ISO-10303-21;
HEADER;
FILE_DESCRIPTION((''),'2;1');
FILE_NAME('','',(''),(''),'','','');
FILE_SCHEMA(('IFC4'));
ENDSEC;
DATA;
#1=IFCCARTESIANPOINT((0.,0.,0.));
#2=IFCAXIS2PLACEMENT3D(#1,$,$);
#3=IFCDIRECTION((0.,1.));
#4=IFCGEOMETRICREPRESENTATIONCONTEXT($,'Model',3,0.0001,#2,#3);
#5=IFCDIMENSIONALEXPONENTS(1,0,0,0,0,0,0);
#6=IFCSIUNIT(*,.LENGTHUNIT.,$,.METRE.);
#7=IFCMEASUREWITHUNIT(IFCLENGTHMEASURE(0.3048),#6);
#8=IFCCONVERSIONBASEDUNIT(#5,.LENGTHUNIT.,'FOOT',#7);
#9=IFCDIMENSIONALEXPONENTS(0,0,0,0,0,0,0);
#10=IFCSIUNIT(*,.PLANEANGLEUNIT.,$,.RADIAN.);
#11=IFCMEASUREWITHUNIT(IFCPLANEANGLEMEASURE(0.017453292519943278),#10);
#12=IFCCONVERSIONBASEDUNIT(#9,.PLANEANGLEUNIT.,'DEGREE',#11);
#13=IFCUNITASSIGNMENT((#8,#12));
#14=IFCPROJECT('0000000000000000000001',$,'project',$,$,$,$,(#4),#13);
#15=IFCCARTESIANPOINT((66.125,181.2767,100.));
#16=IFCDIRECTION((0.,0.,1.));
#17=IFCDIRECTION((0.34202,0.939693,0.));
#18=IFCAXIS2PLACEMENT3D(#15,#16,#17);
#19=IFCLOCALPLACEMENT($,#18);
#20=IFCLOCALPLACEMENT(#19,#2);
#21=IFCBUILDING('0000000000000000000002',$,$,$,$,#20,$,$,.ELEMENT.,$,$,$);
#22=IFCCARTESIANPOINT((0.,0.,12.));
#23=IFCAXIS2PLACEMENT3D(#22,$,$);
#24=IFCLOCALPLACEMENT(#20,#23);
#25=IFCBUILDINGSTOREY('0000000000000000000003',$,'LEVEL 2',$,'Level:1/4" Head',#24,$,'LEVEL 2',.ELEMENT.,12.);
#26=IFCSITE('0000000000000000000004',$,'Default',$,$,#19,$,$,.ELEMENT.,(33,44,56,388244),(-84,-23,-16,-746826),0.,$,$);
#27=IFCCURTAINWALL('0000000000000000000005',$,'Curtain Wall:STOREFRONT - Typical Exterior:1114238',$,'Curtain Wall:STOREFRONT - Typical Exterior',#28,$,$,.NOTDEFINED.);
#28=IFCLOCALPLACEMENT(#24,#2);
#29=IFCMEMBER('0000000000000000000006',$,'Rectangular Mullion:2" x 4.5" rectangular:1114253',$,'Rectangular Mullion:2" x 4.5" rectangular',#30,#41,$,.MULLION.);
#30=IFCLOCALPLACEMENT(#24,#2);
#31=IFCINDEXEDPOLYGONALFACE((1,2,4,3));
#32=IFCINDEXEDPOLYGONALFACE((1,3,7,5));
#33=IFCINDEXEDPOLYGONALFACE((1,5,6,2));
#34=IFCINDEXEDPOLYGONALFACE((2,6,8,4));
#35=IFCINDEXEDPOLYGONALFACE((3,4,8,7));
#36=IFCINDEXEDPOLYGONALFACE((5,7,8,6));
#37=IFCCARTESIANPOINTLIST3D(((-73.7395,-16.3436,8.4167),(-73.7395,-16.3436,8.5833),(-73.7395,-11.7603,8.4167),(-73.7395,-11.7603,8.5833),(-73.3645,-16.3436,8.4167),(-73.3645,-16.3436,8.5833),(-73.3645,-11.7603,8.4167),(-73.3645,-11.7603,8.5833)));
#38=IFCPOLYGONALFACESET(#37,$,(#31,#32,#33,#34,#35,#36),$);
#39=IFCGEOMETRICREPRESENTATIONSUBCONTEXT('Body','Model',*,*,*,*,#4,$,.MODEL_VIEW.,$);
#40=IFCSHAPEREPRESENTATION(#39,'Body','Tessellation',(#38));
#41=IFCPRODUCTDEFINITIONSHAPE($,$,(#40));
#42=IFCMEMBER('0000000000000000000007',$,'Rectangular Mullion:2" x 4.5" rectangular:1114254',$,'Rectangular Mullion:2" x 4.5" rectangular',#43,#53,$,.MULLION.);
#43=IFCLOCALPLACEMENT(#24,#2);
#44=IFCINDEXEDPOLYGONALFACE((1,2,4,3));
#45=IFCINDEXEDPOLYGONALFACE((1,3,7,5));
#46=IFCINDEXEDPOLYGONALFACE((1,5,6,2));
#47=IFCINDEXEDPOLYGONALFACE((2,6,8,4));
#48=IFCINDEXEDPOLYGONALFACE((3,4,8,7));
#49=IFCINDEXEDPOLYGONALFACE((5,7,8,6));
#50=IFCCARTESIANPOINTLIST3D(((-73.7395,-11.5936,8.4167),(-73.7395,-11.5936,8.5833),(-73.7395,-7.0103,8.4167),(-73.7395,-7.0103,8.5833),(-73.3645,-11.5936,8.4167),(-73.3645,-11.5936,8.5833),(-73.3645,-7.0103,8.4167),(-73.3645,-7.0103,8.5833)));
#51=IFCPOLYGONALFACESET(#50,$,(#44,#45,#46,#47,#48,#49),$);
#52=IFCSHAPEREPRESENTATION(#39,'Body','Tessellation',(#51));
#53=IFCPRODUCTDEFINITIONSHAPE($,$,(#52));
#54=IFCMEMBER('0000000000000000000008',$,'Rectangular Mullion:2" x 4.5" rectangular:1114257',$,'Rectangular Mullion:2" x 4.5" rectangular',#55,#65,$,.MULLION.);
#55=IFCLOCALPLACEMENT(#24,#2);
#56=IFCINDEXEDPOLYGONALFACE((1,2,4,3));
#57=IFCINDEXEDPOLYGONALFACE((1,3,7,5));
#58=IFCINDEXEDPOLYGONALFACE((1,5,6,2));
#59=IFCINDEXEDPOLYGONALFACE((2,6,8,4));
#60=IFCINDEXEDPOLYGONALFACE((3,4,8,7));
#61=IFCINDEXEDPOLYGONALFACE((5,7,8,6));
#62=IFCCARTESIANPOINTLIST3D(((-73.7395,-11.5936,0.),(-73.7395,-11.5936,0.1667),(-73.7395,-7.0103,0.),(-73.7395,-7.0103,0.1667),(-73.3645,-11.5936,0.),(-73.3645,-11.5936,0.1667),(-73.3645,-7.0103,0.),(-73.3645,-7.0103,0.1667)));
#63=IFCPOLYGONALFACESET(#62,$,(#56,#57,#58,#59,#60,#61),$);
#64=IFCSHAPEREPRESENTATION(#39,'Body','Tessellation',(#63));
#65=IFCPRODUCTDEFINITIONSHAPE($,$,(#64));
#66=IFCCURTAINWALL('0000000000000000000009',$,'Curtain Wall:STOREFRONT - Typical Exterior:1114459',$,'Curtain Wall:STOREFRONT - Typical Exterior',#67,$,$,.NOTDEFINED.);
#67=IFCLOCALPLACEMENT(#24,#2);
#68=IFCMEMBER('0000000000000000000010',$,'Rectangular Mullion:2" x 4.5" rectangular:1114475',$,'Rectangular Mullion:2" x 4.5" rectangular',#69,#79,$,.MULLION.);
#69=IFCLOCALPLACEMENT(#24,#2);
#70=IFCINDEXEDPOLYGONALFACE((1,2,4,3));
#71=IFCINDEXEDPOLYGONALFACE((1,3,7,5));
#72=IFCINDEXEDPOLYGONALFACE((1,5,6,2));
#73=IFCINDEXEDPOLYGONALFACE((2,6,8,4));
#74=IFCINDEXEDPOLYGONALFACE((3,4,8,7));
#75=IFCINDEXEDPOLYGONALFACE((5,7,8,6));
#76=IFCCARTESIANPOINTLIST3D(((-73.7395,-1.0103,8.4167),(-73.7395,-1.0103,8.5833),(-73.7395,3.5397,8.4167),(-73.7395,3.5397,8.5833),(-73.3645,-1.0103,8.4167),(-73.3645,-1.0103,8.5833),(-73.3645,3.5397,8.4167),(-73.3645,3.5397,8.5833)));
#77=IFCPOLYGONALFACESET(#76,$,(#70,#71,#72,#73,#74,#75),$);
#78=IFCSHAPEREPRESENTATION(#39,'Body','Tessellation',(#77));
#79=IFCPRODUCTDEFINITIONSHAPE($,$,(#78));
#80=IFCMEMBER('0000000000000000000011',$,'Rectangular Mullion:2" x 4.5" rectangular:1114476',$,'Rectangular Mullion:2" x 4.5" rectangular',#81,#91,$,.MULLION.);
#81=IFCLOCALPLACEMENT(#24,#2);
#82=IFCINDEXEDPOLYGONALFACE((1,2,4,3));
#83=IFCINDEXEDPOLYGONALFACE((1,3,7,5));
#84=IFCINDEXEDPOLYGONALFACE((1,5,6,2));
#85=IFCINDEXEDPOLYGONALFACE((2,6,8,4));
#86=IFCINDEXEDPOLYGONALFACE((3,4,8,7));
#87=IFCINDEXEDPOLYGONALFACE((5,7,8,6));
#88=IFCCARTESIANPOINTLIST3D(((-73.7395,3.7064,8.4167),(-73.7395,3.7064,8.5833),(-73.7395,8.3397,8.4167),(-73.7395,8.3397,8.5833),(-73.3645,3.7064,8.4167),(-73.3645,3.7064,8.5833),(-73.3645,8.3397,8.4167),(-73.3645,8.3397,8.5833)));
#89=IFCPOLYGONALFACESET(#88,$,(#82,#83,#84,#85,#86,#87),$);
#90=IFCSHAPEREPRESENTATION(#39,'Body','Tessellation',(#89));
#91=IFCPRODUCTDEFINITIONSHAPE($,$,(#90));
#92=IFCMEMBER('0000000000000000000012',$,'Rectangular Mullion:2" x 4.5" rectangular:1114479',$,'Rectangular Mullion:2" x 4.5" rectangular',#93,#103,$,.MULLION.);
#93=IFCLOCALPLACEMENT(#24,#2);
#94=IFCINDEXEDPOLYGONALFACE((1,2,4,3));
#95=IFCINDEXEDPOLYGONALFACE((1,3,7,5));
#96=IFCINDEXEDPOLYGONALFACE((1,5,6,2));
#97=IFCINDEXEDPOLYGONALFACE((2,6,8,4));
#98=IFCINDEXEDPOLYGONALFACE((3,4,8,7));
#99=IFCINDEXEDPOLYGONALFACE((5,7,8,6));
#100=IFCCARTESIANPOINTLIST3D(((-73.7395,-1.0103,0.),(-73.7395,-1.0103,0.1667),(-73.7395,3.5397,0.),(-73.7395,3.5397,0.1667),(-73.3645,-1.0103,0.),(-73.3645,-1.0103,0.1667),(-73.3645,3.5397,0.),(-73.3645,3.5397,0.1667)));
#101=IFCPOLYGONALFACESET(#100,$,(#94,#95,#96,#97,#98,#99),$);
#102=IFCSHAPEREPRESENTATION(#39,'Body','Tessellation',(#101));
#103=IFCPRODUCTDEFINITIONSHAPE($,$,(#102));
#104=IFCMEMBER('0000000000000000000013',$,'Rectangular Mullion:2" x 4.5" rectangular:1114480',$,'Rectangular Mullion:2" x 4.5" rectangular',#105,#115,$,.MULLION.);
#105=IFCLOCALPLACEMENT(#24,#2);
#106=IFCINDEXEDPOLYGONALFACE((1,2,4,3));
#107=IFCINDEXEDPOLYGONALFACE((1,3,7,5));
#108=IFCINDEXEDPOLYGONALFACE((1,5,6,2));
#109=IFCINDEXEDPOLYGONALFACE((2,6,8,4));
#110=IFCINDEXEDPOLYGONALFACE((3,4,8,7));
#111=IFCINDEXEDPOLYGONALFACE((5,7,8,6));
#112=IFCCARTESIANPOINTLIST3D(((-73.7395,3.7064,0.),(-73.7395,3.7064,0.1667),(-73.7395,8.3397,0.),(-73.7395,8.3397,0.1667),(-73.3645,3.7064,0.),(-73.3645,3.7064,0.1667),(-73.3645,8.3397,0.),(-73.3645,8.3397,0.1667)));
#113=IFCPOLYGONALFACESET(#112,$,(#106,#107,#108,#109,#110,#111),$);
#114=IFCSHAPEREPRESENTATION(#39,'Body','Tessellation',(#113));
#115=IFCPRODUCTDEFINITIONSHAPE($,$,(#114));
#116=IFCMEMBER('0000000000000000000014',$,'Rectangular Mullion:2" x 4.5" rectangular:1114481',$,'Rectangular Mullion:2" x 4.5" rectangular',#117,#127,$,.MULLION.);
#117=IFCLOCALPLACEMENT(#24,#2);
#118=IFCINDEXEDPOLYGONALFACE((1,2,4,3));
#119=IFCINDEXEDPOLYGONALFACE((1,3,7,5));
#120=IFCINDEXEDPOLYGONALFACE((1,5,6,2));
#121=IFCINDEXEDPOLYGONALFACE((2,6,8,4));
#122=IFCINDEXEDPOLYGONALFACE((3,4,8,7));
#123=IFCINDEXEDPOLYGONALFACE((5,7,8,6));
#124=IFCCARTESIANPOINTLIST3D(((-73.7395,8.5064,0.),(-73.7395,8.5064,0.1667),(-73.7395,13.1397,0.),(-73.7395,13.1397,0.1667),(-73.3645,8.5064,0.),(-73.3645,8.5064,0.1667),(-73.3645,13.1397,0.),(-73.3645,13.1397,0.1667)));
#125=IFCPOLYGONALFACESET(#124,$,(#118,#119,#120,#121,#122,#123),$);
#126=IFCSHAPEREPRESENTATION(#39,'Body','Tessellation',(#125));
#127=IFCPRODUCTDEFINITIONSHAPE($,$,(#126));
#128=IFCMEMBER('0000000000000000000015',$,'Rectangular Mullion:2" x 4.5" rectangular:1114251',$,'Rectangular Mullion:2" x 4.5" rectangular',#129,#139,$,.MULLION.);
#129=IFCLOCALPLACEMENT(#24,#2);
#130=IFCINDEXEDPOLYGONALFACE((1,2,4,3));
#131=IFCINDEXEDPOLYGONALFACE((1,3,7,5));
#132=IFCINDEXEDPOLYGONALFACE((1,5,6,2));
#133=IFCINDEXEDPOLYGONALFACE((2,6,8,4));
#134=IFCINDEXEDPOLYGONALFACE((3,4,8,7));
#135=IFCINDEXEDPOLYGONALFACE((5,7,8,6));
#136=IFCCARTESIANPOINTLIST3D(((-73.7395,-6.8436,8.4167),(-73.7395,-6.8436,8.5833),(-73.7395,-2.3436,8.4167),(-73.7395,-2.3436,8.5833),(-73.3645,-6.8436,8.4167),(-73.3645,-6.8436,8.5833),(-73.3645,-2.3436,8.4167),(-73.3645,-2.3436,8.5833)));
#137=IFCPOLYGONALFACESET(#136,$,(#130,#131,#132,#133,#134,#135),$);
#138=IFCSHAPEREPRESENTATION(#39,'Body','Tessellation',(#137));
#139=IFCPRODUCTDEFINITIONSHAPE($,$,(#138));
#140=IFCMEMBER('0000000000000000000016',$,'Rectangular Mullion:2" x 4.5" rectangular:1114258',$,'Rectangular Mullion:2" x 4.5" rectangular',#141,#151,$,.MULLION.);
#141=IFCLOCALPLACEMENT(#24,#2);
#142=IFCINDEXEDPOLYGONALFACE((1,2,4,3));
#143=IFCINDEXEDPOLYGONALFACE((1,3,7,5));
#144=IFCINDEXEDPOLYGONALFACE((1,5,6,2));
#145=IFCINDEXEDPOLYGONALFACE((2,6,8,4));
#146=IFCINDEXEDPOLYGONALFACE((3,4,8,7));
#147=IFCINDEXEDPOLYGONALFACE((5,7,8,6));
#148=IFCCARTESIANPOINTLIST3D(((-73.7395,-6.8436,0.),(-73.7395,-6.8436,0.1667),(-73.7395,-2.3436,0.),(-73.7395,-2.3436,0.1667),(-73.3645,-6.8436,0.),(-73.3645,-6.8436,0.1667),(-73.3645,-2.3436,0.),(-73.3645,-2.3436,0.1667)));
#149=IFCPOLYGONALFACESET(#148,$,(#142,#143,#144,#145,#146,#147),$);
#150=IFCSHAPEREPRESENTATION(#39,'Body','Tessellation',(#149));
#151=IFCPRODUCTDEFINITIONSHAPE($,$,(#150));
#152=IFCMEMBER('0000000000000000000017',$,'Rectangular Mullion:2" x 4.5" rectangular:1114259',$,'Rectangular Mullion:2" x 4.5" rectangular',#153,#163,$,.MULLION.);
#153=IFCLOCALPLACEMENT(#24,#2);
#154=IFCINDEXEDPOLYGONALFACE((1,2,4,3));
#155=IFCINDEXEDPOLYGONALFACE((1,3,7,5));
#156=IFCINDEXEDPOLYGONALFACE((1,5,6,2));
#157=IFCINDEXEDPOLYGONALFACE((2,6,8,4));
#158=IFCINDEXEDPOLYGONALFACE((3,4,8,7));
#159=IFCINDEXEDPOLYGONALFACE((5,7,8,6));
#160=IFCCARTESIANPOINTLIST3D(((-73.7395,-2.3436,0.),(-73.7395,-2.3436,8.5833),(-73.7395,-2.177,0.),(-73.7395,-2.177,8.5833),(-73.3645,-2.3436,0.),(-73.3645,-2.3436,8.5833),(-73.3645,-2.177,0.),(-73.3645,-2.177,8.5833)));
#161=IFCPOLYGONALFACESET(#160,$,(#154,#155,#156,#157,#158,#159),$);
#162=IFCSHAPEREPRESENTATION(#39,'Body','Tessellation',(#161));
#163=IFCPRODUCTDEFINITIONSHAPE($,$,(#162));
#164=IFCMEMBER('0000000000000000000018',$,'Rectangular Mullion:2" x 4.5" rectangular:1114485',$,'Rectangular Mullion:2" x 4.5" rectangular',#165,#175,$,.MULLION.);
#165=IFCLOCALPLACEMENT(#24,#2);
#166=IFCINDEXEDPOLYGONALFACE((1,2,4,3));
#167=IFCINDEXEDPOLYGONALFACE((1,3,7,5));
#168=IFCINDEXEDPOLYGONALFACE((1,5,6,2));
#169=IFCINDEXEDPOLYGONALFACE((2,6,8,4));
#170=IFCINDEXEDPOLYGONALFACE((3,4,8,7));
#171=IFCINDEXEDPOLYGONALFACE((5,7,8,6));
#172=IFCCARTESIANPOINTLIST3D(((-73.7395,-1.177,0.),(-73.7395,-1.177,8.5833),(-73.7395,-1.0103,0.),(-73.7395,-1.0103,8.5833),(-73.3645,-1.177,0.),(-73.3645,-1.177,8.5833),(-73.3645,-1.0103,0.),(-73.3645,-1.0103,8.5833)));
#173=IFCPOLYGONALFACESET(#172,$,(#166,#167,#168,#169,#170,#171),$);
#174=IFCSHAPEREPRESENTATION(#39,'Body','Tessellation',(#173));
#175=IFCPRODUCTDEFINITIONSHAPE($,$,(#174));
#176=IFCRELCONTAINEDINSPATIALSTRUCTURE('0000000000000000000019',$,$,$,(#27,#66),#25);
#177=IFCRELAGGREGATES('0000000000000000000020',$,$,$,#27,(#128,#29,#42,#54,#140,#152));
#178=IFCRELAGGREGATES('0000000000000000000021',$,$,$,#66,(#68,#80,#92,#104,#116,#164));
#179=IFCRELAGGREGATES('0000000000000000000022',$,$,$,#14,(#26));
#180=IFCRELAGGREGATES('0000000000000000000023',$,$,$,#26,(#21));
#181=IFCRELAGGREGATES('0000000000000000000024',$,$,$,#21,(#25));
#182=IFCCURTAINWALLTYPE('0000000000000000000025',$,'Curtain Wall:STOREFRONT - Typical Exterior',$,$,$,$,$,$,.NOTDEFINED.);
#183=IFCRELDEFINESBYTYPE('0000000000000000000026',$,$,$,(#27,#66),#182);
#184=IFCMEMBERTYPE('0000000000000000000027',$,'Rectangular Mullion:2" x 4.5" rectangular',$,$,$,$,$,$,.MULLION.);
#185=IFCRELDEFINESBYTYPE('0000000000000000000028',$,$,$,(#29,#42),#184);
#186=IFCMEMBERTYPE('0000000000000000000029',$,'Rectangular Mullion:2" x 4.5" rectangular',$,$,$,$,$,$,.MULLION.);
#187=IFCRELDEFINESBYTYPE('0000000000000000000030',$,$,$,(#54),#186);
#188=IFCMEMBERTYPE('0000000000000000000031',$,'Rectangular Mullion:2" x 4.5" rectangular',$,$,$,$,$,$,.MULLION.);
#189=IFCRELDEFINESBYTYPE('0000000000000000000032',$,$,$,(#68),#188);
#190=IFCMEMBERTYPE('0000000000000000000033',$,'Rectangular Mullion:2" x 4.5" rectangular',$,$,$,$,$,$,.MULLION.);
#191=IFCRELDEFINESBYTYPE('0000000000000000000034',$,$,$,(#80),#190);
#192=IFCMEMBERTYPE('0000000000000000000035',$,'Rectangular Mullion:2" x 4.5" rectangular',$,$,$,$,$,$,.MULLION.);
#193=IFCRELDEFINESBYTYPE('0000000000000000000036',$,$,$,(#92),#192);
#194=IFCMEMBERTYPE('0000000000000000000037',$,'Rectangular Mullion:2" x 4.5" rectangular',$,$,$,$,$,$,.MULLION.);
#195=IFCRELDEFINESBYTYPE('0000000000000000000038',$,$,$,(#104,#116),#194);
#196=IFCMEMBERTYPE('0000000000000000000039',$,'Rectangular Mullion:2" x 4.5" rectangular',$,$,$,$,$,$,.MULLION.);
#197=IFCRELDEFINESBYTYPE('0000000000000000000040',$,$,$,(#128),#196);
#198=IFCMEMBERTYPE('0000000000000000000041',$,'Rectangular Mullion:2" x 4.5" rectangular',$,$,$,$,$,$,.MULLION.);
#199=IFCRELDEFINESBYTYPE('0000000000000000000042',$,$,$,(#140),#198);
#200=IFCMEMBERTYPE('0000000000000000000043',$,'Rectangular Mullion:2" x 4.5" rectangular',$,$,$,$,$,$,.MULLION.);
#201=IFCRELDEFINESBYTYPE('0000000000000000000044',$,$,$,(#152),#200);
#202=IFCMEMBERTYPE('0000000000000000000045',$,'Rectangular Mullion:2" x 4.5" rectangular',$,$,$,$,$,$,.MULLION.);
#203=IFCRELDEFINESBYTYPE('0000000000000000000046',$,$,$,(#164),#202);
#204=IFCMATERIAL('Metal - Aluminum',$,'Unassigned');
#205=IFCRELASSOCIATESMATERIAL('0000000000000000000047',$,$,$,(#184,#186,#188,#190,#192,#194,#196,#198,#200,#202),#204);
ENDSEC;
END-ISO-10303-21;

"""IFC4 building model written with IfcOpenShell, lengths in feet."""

from ifc_helpers import new_model, entity, si_unit, converted_unit, direction, frame, origin, origin_2d_with_axis, place, context, subcontext, project, spatial, rectangle, extrude, source, transform, mapped, material, material_profile, profile_set, type_object, type_shapes, element, aggregate, save


model = new_model("IFC4")

# Units and contexts
model_context = context("Model", 3, precision=0.0001, world=origin(), true_north=direction((0.0, 1.0)))
body_context = subcontext(model_context, "Body", "Model", "MODEL_VIEW")
ifc_project = project(units=[converted_unit("LENGTHUNIT", "FOOT", entity("IfcLengthMeasure", 0.3048), si_unit("LENGTHUNIT", "METRE"), dimensions=[1, 0, 0, 0, 0, 0, 0]), converted_unit("PLANEANGLEUNIT", "DEGREE", entity("IfcPlaneAngleMeasure", 0.017453292519943278), si_unit("PLANEANGLEUNIT", "RADIAN"), dimensions=[0, 0, 0, 0, 0, 0, 0])], contexts=[model_context])

# Site, building, storey
site_placement = place(None, frame((66.125, 181.2767, 100.0), z_axis=(0.0, 0.0, 1.0), x_axis=(0.34202, 0.939693, 0.0)))
site = spatial("IfcSite", under=ifc_project, at=site_placement, Name="Default", CompositionType="ELEMENT", RefLatitude=(33, 44, 56, 388244), RefLongitude=(-84, -23, -16, -746826), RefElevation=0.0)
building_placement = place(site_placement, origin())
building = spatial("IfcBuilding", under=site, at=building_placement, CompositionType="ELEMENT")
storey_placement = place(building_placement, frame((0.0, 0.0, 12.0)))
storey = spatial("IfcBuildingStorey", under=building, at=storey_placement, Name="LEVEL 2", ObjectType="Level:1/4\" Head", LongName="LEVEL 2", CompositionType="ELEMENT", Elevation=12.0)

# Curtain walls, members
curtain_wall_type = type_object("IfcCurtainWallType", Name="Curtain Wall:STOREFRONT - Typical Exterior", PredefinedType="NOTDEFINED")
curtain_wall_1_placement = place(storey_placement, frame((0.0, 0.0, -12.0)))
curtain_wall_1 = element("IfcCurtainWall", 1, at=curtain_wall_1_placement, inside=storey, type_object=curtain_wall_type, Name="Curtain Wall:STOREFRONT - Typical Exterior:1114238", ObjectType="Curtain Wall:STOREFRONT - Typical Exterior", PredefinedType="NOTDEFINED")
ifc_material_1 = material(Name="Metal - Aluminum", Category="Unassigned")
ifc_material_profile = material_profile(ifc_material_1, rectangle(XDim=0.1667, YDim=0.375, at=origin_2d_with_axis()), Name="2\" x 4.5\" rectangular")
ifc_profile_set = profile_set([ifc_material_profile], Name="2\" x 4.5\" rectangular")
member_type_1 = type_object("IfcMemberType", Name="Rectangular Mullion:2\" x 4.5\" rectangular", PredefinedType="MULLION", material=ifc_profile_set)
shared_shape_1 = source(origin(), body_context, "Body", "SweptSolid", [
    extrude(rectangle(XDim=0.1667, YDim=0.375, at=origin_2d_with_axis()), frame((-0.0833, 0.0, -4.5833), z_axis=(0.0, 0.0, 1.0), x_axis=(-1.0, 0.0, 0.0)), (0.0, 0.0, 1.0), 4.5833),
])
type_shapes(member_type_1, [shared_shape_1])
member_1_placement = place(curtain_wall_1_placement, frame((-73.552, -11.7603, 20.5833), z_axis=(0.0, 1.0, 0.0), x_axis=(0.0, 0.0, 1.0)))
member_1 = element("IfcMember", 2, at=member_1_placement, type_object=member_type_1, Name="Rectangular Mullion:2\" x 4.5\" rectangular:1114253", ObjectType="Rectangular Mullion:2\" x 4.5\" rectangular", PredefinedType="MULLION", context=body_context, shape_type="MappedRepresentation", body=[
    mapped(shared_shape_1, transform((0.0, 0.0, 0.0), scale=1.0)),
])
member_2_placement = place(curtain_wall_1_placement, frame((-73.552, -7.0103, 20.5833), z_axis=(0.0, 1.0, 0.0), x_axis=(0.0, 0.0, 1.0)))
member_2 = element("IfcMember", 3, at=member_2_placement, type_object=member_type_1, Name="Rectangular Mullion:2\" x 4.5\" rectangular:1114254", ObjectType="Rectangular Mullion:2\" x 4.5\" rectangular", PredefinedType="MULLION", context=body_context, shape_type="MappedRepresentation", body=[
    mapped(shared_shape_1, transform((0.0, 0.0, 0.0), scale=1.0)),
])
member_type_2 = type_object("IfcMemberType", Name="Rectangular Mullion:2\" x 4.5\" rectangular", PredefinedType="MULLION", material=ifc_profile_set)
shared_shape_2 = source(origin(), body_context, "Body", "SweptSolid", [
    extrude(rectangle(XDim=0.1667, YDim=0.375, at=origin_2d_with_axis()), frame((-0.0833, 0.0, -4.5833), z_axis=(0.0, 0.0, 1.0), x_axis=(-1.0, 0.0, 0.0)), (0.0, 0.0, 1.0), 4.5833),
])
type_shapes(member_type_2, [shared_shape_2])
member_3_placement = place(curtain_wall_1_placement, frame((-73.552, -11.5936, 12.0), z_axis=(0.0, -1.0, 0.0), x_axis=(0.0, 0.0, -1.0)))
member_3 = element("IfcMember", 4, at=member_3_placement, type_object=member_type_2, Name="Rectangular Mullion:2\" x 4.5\" rectangular:1114257", ObjectType="Rectangular Mullion:2\" x 4.5\" rectangular", PredefinedType="MULLION", context=body_context, shape_type="MappedRepresentation", body=[
    mapped(shared_shape_2, transform((0.0, 0.0, 0.0), scale=1.0)),
])
curtain_wall_2_placement = place(storey_placement, frame((0.0, 0.0, -12.0)))
curtain_wall_2 = element("IfcCurtainWall", 5, at=curtain_wall_2_placement, inside=storey, type_object=curtain_wall_type, Name="Curtain Wall:STOREFRONT - Typical Exterior:1114459", ObjectType="Curtain Wall:STOREFRONT - Typical Exterior", PredefinedType="NOTDEFINED")
member_type_3 = type_object("IfcMemberType", Name="Rectangular Mullion:2\" x 4.5\" rectangular", PredefinedType="MULLION", material=ifc_profile_set)
shared_shape_3 = source(origin(), body_context, "Body", "SweptSolid", [
    extrude(rectangle(XDim=0.1667, YDim=0.375, at=origin_2d_with_axis()), frame((-0.0833, 0.0, -4.55), z_axis=(0.0, 0.0, 1.0), x_axis=(-1.0, 0.0, 0.0)), (0.0, 0.0, 1.0), 4.55),
])
type_shapes(member_type_3, [shared_shape_3])
member_4_placement = place(curtain_wall_2_placement, frame((-73.552, 3.5397, 20.5833), z_axis=(0.0, 1.0, 0.0), x_axis=(0.0, 0.0, 1.0)))
member_4 = element("IfcMember", 6, at=member_4_placement, type_object=member_type_3, Name="Rectangular Mullion:2\" x 4.5\" rectangular:1114475", ObjectType="Rectangular Mullion:2\" x 4.5\" rectangular", PredefinedType="MULLION", context=body_context, shape_type="MappedRepresentation", body=[
    mapped(shared_shape_3, transform((0.0, 0.0, 0.0), scale=1.0)),
])
member_type_4 = type_object("IfcMemberType", Name="Rectangular Mullion:2\" x 4.5\" rectangular", PredefinedType="MULLION", material=ifc_profile_set)
shared_shape_4 = source(origin(), body_context, "Body", "SweptSolid", [
    extrude(rectangle(XDim=0.1667, YDim=0.375, at=origin_2d_with_axis()), frame((-0.0833, 0.0, -4.6333), z_axis=(0.0, 0.0, 1.0), x_axis=(-1.0, 0.0, 0.0)), (0.0, 0.0, 1.0), 4.6333),
])
type_shapes(member_type_4, [shared_shape_4])
member_5_placement = place(curtain_wall_2_placement, frame((-73.552, 8.3397, 20.5833), z_axis=(0.0, 1.0, 0.0), x_axis=(0.0, 0.0, 1.0)))
member_5 = element("IfcMember", 7, at=member_5_placement, type_object=member_type_4, Name="Rectangular Mullion:2\" x 4.5\" rectangular:1114476", ObjectType="Rectangular Mullion:2\" x 4.5\" rectangular", PredefinedType="MULLION", context=body_context, shape_type="MappedRepresentation", body=[
    mapped(shared_shape_4, transform((0.0, 0.0, 0.0), scale=1.0)),
])
member_type_5 = type_object("IfcMemberType", Name="Rectangular Mullion:2\" x 4.5\" rectangular", PredefinedType="MULLION", material=ifc_profile_set)
shared_shape_5 = source(origin(), body_context, "Body", "SweptSolid", [
    extrude(rectangle(XDim=0.1667, YDim=0.375, at=origin_2d_with_axis()), frame((-0.0833, 0.0, -4.55), z_axis=(0.0, 0.0, 1.0), x_axis=(-1.0, 0.0, 0.0)), (0.0, 0.0, 1.0), 4.55),
])
type_shapes(member_type_5, [shared_shape_5])
member_6_placement = place(curtain_wall_2_placement, frame((-73.552, -1.0103, 12.0), z_axis=(0.0, -1.0, 0.0), x_axis=(0.0, 0.0, -1.0)))
member_6 = element("IfcMember", 8, at=member_6_placement, type_object=member_type_5, Name="Rectangular Mullion:2\" x 4.5\" rectangular:1114479", ObjectType="Rectangular Mullion:2\" x 4.5\" rectangular", PredefinedType="MULLION", context=body_context, shape_type="MappedRepresentation", body=[
    mapped(shared_shape_5, transform((0.0, 0.0, 0.0), scale=1.0)),
])
member_type_6 = type_object("IfcMemberType", Name="Rectangular Mullion:2\" x 4.5\" rectangular", PredefinedType="MULLION", material=ifc_profile_set)
shared_shape_6 = source(origin(), body_context, "Body", "SweptSolid", [
    extrude(rectangle(XDim=0.1667, YDim=0.375, at=origin_2d_with_axis()), frame((-0.0833, 0.0, -4.6333), z_axis=(0.0, 0.0, 1.0), x_axis=(-1.0, 0.0, 0.0)), (0.0, 0.0, 1.0), 4.6333),
])
type_shapes(member_type_6, [shared_shape_6])
member_7_placement = place(curtain_wall_2_placement, frame((-73.552, 3.7064, 12.0), z_axis=(0.0, -1.0, 0.0), x_axis=(0.0, 0.0, -1.0)))
member_7 = element("IfcMember", 9, at=member_7_placement, type_object=member_type_6, Name="Rectangular Mullion:2\" x 4.5\" rectangular:1114480", ObjectType="Rectangular Mullion:2\" x 4.5\" rectangular", PredefinedType="MULLION", context=body_context, shape_type="MappedRepresentation", body=[
    mapped(shared_shape_6, transform((0.0, 0.0, 0.0), scale=1.0)),
])
member_8_placement = place(curtain_wall_2_placement, frame((-73.552, 8.5064, 12.0), z_axis=(0.0, -1.0, 0.0), x_axis=(0.0, 0.0, -1.0)))
member_8 = element("IfcMember", 10, at=member_8_placement, type_object=member_type_6, Name="Rectangular Mullion:2\" x 4.5\" rectangular:1114481", ObjectType="Rectangular Mullion:2\" x 4.5\" rectangular", PredefinedType="MULLION", context=body_context, shape_type="MappedRepresentation", body=[
    mapped(shared_shape_6, transform((0.0, 0.0, 0.0), scale=1.0)),
])

# Members
member_type_7 = type_object("IfcMemberType", Name="Rectangular Mullion:2\" x 4.5\" rectangular", PredefinedType="MULLION", material=ifc_profile_set)
shared_shape_7 = source(origin(), body_context, "Body", "SweptSolid", [
    extrude(rectangle(XDim=0.1667, YDim=0.375, at=origin_2d_with_axis()), frame((-0.0833, 0.0, -4.5), z_axis=(0.0, 0.0, 1.0), x_axis=(-1.0, 0.0, 0.0)), (0.0, 0.0, 1.0), 4.5),
])
type_shapes(member_type_7, [shared_shape_7])
member_9_placement = place(curtain_wall_1_placement, frame((-73.552, -2.3436, 20.5833), z_axis=(0.0, 1.0, 0.0), x_axis=(0.0, 0.0, 1.0)))
member_9 = element("IfcMember", 11, at=member_9_placement, type_object=member_type_7, Name="Rectangular Mullion:2\" x 4.5\" rectangular:1114251", ObjectType="Rectangular Mullion:2\" x 4.5\" rectangular", PredefinedType="MULLION", context=body_context, shape_type="MappedRepresentation", body=[
    mapped(shared_shape_7, transform((0.0, 0.0, 0.0), scale=1.0)),
])
member_type_8 = type_object("IfcMemberType", Name="Rectangular Mullion:2\" x 4.5\" rectangular", PredefinedType="MULLION", material=ifc_profile_set)
shared_shape_8 = source(origin(), body_context, "Body", "SweptSolid", [
    extrude(rectangle(XDim=0.1667, YDim=0.375, at=origin_2d_with_axis()), frame((-0.0833, 0.0, -4.5), z_axis=(0.0, 0.0, 1.0), x_axis=(-1.0, 0.0, 0.0)), (0.0, 0.0, 1.0), 4.5),
])
type_shapes(member_type_8, [shared_shape_8])
member_10_placement = place(curtain_wall_1_placement, frame((-73.552, -6.8436, 12.0), z_axis=(0.0, -1.0, 0.0), x_axis=(0.0, 0.0, -1.0)))
member_10 = element("IfcMember", 12, at=member_10_placement, type_object=member_type_8, Name="Rectangular Mullion:2\" x 4.5\" rectangular:1114258", ObjectType="Rectangular Mullion:2\" x 4.5\" rectangular", PredefinedType="MULLION", context=body_context, shape_type="MappedRepresentation", body=[
    mapped(shared_shape_8, transform((0.0, 0.0, 0.0), scale=1.0)),
])
member_type_9 = type_object("IfcMemberType", Name="Rectangular Mullion:2\" x 4.5\" rectangular", PredefinedType="MULLION", material=ifc_profile_set)
shared_shape_9 = source(origin(), body_context, "Body", "SweptSolid", [
    extrude(rectangle(XDim=0.1667, YDim=0.375, at=origin_2d_with_axis()), frame((-0.0833, 0.0, -8.5833), z_axis=(0.0, 0.0, 1.0), x_axis=(-1.0, 0.0, 0.0)), (0.0, 0.0, 1.0), 8.5833),
])
type_shapes(member_type_9, [shared_shape_9])
member_11_placement = place(curtain_wall_1_placement, frame((-73.552, -2.177, 12.0), z_axis=(0.0, 0.0, -1.0), x_axis=(0.0, 1.0, 0.0)))
member_11 = element("IfcMember", 13, at=member_11_placement, type_object=member_type_9, Name="Rectangular Mullion:2\" x 4.5\" rectangular:1114259", ObjectType="Rectangular Mullion:2\" x 4.5\" rectangular", PredefinedType="MULLION", context=body_context, shape_type="MappedRepresentation", body=[
    mapped(shared_shape_9, transform((0.0, 0.0, 0.0), scale=1.0)),
])
member_type_10 = type_object("IfcMemberType", Name="Rectangular Mullion:2\" x 4.5\" rectangular", PredefinedType="MULLION", material=ifc_profile_set)
shared_shape_10 = source(origin(), body_context, "Body", "SweptSolid", [
    extrude(rectangle(XDim=0.1667, YDim=0.375, at=origin_2d_with_axis()), frame((-0.0833, 0.0, -8.5833), z_axis=(0.0, 0.0, 1.0), x_axis=(-1.0, 0.0, 0.0)), (0.0, 0.0, 1.0), 8.5833),
])
type_shapes(member_type_10, [shared_shape_10])
member_12_placement = place(curtain_wall_2_placement, frame((-73.552, -1.177, 20.5833), z_axis=(0.0, 0.0, 1.0), x_axis=(0.0, -1.0, 0.0)))
member_12 = element("IfcMember", 14, at=member_12_placement, type_object=member_type_10, Name="Rectangular Mullion:2\" x 4.5\" rectangular:1114485", ObjectType="Rectangular Mullion:2\" x 4.5\" rectangular", PredefinedType="MULLION", context=body_context, shape_type="MappedRepresentation", body=[
    mapped(shared_shape_10, transform((0.0, 0.0, 0.0), scale=1.0)),
])

aggregate(curtain_wall_1, [member_9, member_1, member_2, member_3, member_10, member_11])
aggregate(curtain_wall_2, [member_4, member_5, member_6, member_7, member_8, member_12])

save(model, "model.ifc")
